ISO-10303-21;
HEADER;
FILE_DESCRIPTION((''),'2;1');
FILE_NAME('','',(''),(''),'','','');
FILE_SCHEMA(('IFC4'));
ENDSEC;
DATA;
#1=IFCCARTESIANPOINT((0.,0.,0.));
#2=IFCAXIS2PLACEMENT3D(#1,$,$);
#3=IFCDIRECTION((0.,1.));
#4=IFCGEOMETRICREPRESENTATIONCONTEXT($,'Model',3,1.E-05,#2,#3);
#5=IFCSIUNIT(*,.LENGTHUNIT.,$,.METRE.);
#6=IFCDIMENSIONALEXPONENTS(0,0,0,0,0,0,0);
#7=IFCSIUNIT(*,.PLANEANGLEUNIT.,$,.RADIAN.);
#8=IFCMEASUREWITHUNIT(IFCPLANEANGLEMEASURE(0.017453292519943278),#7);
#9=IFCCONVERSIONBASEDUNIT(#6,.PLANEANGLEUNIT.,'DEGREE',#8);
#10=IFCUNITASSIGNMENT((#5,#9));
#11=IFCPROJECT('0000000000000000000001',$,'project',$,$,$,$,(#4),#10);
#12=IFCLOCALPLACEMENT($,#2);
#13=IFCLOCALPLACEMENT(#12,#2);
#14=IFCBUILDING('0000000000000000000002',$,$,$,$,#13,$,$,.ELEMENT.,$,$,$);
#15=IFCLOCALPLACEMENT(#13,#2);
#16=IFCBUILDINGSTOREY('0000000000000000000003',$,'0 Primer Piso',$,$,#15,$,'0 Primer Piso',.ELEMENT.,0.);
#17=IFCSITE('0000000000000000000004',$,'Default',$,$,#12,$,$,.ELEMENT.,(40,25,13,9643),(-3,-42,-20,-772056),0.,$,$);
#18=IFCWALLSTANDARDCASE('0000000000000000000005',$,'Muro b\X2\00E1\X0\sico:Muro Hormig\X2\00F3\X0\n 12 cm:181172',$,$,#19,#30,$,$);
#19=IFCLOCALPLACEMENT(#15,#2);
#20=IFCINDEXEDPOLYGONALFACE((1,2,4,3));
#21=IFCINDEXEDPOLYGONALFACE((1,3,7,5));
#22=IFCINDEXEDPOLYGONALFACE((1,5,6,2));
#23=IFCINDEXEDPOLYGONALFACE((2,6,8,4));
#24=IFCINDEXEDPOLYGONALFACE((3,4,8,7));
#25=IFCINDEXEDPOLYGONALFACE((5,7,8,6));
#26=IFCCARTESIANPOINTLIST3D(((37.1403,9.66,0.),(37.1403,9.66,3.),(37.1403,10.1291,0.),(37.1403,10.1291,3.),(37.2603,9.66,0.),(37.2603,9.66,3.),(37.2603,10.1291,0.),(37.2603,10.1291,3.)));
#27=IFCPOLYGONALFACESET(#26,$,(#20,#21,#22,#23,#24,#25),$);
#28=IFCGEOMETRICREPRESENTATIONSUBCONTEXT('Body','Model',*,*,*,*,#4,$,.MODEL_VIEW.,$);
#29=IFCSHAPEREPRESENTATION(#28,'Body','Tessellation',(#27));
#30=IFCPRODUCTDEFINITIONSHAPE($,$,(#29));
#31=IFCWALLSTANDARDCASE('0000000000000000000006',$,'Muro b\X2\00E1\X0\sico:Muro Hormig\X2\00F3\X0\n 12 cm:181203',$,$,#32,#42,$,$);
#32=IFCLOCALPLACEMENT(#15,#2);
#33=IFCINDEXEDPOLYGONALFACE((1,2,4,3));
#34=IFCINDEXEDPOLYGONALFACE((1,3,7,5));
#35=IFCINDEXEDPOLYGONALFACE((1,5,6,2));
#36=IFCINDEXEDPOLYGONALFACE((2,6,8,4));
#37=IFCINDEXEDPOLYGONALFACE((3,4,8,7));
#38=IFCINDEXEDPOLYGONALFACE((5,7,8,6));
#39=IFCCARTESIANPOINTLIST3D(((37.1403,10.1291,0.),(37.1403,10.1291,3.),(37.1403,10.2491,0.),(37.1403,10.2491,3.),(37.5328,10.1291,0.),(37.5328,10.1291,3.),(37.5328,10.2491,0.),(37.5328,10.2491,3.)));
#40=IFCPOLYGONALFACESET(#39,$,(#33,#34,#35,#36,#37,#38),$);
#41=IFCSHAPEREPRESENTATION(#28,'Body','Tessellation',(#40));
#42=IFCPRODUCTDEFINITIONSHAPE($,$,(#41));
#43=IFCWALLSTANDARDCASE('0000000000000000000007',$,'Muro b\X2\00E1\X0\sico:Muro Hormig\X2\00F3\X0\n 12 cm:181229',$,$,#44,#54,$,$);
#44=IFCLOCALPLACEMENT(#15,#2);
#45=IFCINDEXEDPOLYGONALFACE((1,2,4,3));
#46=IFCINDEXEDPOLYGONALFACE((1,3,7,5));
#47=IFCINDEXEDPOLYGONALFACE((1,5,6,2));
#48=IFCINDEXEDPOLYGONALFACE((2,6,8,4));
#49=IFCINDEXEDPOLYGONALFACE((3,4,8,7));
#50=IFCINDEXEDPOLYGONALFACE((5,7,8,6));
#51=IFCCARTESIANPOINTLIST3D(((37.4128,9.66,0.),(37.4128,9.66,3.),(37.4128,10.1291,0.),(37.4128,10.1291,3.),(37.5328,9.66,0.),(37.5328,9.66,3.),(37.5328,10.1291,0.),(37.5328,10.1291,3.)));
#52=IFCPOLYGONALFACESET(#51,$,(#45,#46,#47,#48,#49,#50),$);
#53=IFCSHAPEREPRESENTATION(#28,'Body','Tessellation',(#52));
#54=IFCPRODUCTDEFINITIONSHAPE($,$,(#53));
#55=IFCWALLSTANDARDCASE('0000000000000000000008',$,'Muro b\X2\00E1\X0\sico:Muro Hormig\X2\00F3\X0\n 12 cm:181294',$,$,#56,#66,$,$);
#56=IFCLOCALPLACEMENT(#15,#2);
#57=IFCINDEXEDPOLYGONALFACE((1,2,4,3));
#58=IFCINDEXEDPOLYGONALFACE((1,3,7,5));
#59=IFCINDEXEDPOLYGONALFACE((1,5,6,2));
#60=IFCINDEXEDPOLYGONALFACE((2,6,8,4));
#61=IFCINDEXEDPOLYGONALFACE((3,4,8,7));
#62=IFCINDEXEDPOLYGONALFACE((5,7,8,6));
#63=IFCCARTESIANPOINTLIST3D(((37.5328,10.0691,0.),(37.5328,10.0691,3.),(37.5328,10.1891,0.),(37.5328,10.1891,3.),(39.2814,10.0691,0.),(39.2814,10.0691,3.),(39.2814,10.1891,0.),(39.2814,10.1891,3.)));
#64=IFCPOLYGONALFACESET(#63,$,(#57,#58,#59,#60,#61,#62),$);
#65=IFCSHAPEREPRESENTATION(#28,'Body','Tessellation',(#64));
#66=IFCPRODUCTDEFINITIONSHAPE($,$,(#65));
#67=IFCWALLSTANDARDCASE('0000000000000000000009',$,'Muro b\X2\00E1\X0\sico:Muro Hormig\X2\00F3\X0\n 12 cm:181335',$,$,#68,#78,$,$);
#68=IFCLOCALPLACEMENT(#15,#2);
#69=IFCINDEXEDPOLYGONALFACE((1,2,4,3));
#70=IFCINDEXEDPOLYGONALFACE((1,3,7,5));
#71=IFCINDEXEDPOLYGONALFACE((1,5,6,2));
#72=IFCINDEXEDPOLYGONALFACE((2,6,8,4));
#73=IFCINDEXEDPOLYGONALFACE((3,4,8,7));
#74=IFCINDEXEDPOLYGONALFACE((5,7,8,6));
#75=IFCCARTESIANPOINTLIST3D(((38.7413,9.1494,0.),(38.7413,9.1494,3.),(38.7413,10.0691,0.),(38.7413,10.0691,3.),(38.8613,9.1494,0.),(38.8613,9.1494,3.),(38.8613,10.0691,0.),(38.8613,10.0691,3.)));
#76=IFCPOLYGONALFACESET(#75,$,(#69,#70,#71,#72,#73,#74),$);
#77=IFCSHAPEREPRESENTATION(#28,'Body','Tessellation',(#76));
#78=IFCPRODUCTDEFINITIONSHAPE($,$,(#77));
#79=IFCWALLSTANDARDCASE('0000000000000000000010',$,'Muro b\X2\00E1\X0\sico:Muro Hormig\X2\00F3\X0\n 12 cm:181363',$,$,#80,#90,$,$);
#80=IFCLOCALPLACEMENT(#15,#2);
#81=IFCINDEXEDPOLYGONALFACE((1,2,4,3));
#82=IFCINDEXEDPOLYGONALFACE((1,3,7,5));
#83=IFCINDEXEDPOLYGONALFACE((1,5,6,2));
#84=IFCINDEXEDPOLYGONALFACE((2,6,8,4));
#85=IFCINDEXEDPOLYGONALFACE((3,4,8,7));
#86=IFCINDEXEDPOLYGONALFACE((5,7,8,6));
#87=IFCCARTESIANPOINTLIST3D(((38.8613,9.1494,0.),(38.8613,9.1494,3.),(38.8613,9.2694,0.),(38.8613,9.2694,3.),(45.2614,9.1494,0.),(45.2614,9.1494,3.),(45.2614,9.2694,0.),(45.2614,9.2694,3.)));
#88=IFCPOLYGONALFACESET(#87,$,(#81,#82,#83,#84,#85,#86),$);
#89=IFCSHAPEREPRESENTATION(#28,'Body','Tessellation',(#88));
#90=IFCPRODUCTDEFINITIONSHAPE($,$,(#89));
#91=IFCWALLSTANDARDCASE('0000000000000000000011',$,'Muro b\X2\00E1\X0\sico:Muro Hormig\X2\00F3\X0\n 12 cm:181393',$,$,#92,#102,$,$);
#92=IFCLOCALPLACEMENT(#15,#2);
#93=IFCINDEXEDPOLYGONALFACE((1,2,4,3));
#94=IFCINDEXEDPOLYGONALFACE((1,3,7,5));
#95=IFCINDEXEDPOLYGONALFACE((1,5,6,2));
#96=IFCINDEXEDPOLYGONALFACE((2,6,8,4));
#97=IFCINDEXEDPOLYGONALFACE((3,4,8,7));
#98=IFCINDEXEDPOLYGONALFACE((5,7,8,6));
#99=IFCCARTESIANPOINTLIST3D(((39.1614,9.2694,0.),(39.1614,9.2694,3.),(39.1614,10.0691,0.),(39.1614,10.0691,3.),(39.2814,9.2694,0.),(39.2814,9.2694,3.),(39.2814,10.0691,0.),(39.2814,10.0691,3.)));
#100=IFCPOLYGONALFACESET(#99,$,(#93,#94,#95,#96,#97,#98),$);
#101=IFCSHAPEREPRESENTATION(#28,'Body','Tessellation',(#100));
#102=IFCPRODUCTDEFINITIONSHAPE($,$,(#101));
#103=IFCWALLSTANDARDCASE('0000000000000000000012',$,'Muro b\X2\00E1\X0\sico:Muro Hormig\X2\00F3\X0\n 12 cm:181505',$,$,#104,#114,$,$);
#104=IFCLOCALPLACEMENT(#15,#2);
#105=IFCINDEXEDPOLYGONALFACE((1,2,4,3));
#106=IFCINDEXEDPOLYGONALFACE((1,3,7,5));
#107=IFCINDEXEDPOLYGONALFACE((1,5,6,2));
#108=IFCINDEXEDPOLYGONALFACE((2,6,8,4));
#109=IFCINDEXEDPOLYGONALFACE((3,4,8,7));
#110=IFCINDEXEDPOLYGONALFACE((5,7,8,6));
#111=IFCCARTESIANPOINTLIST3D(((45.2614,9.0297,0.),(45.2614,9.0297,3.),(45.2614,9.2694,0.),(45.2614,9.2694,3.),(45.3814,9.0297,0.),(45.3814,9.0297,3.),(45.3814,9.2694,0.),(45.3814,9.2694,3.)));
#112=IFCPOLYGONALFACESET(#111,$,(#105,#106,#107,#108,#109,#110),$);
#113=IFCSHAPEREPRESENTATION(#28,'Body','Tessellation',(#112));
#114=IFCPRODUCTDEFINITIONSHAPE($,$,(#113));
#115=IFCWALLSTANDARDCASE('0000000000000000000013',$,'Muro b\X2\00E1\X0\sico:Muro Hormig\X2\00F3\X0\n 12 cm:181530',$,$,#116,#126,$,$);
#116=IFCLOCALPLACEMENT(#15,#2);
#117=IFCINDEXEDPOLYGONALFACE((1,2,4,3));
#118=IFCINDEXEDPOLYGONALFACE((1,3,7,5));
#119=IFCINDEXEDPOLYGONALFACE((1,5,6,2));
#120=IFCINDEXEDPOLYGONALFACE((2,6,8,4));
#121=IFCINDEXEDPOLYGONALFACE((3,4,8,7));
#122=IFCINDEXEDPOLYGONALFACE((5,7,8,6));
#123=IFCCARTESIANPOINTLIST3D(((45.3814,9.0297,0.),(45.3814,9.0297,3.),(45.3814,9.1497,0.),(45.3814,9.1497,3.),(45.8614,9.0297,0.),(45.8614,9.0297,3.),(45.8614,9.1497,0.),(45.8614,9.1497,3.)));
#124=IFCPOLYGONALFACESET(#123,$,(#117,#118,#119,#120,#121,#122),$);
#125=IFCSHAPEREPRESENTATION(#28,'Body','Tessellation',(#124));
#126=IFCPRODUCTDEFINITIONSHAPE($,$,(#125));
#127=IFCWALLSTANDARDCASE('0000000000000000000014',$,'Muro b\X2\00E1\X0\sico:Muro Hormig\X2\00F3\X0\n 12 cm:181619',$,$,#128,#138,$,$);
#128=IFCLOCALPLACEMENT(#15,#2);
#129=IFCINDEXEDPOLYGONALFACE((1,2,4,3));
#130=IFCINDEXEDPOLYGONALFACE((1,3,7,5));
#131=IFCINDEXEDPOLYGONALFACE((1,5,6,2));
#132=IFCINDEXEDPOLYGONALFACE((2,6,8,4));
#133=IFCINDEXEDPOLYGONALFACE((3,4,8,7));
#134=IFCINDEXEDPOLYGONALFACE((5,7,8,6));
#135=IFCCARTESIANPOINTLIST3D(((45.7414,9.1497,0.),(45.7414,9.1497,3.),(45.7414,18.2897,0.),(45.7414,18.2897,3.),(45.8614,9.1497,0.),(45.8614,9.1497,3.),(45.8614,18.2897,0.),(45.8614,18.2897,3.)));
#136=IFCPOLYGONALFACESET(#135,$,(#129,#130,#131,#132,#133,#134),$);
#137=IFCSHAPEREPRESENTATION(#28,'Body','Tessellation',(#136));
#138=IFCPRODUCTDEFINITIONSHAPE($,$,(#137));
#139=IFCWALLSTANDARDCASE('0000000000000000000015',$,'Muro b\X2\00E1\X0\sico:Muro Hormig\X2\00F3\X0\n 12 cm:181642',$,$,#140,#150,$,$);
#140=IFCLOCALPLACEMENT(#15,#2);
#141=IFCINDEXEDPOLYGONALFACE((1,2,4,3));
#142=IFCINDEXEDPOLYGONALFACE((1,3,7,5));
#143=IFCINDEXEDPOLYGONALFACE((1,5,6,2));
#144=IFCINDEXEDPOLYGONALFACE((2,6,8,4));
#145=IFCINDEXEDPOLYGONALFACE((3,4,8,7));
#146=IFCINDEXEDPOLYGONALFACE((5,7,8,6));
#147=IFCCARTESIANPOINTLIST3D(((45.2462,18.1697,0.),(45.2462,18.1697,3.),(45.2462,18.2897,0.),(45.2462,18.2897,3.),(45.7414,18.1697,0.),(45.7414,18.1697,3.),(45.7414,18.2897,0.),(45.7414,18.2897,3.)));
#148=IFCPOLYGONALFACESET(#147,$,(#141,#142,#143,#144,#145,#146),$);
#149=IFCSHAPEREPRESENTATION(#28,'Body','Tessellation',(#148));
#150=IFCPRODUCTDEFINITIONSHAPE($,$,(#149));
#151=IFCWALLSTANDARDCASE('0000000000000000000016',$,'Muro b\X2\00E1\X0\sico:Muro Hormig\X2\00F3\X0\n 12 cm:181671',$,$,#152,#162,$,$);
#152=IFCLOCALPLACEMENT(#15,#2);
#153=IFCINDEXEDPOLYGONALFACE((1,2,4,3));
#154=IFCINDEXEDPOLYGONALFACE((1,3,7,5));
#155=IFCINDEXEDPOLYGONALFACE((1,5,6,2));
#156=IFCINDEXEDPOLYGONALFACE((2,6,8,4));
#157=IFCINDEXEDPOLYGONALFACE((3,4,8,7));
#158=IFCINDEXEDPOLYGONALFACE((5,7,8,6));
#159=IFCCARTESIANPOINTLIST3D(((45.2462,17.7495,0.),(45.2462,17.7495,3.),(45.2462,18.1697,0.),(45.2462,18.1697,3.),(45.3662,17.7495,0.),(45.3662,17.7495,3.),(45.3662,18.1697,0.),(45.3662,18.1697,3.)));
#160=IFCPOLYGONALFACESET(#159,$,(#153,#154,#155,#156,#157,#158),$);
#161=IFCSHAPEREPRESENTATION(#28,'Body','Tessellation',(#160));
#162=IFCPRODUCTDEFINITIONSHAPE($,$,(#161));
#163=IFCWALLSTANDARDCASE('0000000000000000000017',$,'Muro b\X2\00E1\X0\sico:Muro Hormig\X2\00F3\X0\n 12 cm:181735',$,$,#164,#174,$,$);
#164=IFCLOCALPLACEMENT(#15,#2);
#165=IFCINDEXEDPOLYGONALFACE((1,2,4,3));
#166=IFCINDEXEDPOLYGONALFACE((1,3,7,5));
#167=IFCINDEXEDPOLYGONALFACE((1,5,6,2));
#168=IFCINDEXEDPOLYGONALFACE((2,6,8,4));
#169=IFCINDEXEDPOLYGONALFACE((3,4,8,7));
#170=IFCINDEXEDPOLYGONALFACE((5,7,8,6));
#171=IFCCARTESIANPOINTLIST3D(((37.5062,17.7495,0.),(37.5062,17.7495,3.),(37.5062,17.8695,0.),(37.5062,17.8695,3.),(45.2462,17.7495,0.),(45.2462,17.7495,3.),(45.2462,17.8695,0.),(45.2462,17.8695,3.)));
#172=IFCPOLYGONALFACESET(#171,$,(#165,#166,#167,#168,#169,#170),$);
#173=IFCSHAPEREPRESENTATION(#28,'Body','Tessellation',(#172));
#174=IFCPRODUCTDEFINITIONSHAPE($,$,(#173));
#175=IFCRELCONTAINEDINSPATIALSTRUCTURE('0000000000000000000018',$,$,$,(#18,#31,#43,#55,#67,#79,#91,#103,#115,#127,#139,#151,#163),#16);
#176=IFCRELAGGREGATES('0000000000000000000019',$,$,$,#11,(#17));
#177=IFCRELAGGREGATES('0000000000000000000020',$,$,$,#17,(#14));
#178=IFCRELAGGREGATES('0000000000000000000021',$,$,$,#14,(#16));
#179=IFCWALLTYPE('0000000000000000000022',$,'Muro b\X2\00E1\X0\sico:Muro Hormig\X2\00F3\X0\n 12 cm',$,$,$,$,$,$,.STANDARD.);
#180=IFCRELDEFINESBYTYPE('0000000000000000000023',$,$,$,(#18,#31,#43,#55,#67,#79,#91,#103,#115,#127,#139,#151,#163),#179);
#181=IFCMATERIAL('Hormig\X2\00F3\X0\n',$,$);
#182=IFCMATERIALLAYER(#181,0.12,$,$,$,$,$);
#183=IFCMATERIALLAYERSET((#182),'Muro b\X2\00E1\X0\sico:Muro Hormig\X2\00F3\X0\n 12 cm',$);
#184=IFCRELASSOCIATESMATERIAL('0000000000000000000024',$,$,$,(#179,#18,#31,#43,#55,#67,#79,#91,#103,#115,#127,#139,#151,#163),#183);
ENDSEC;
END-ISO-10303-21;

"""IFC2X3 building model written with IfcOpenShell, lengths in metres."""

from ifc_helpers import new_model, entity, si_unit, converted_unit, direction, frame, frame_2d, origin, place, context, subcontext, project, spatial, rectangle, extrude, material, layer, layer_set, layer_usage, type_object, element, save


model = new_model("IFC2X3")

# Units and contexts
model_context = context("Model", 3, precision=1e-05, world=origin(), true_north=direction((0.0, 1.0)))
body_context = subcontext(model_context, "Body", "Model", "MODEL_VIEW")
ifc_project = project(units=[si_unit("LENGTHUNIT", "METRE"), converted_unit("PLANEANGLEUNIT", "DEGREE", entity("IfcPlaneAngleMeasure", 0.017453292519943278), si_unit("PLANEANGLEUNIT", "RADIAN"), dimensions=[0, 0, 0, 0, 0, 0, 0])], contexts=[model_context])

# Site, building, storey
site_placement = place(None, origin())
site = spatial("IfcSite", under=ifc_project, at=site_placement, Name="Default", CompositionType="ELEMENT", RefLatitude=(40, 25, 13, 9643), RefLongitude=(-3, -42, -20, -772056), RefElevation=0.0)
building_placement = place(site_placement, origin())
building = spatial("IfcBuilding", under=site, at=building_placement, CompositionType="ELEMENT")
storey_placement = place(building_placement, origin())
storey = spatial("IfcBuildingStorey", under=building, at=storey_placement, Name="0 Primer Piso", LongName="0 Primer Piso", CompositionType="ELEMENT", Elevation=0.0)

# Walls
ifc_material = material(Name="Hormigón")
ifc_layer = layer(ifc_material, 0.12)
ifc_layer_set = layer_set([ifc_layer], Name="Muro básico:Muro Hormigón 12 cm")
wall_type = type_object("IfcWallType", Name="Muro básico:Muro Hormigón 12 cm", PredefinedType="STANDARD", material=ifc_layer_set)
ifc_layer_usage_1 = layer_usage(ifc_layer_set, "AXIS2", "NEGATIVE", 0.06)
wall_1_placement = place(storey_placement, frame((37.2003, 9.66, 0.0), z_axis=(0.0, 0.0, 1.0), x_axis=(0.0, 1.0, 0.0)))
element("IfcWallStandardCase", 1, at=wall_1_placement, inside=storey, type_object=wall_type, material=ifc_layer_usage_1, Name="Muro básico:Muro Hormigón 12 cm:181172", context=body_context, shape_type="SweptSolid", body=[
    extrude(rectangle(XDim=0.4691, YDim=0.12, at=frame_2d((0.2346, 0.0), x_axis=(-1.0, 0.0))), origin(), (0.0, 0.0, 1.0), 3.0),
])
ifc_layer_usage_2 = layer_usage(ifc_layer_set, "AXIS2", "NEGATIVE", 0.06)
wall_2_placement = place(storey_placement, frame((37.1403, 10.1891, 0.0)))
element("IfcWallStandardCase", 2, at=wall_2_placement, inside=storey, type_object=wall_type, material=ifc_layer_usage_2, Name="Muro básico:Muro Hormigón 12 cm:181203", context=body_context, shape_type="SweptSolid", body=[
    extrude(rectangle(XDim=0.3925, YDim=0.12, at=frame_2d((0.1963, 0.0), x_axis=(-1.0, 0.0))), origin(), (0.0, 0.0, 1.0), 3.0),
])
ifc_layer_usage_3 = layer_usage(ifc_layer_set, "AXIS2", "NEGATIVE", 0.06)
wall_3_placement = place(storey_placement, frame((37.4728, 10.1291, 0.0), z_axis=(0.0, 0.0, 1.0), x_axis=(0.0, -1.0, 0.0)))
element("IfcWallStandardCase", 3, at=wall_3_placement, inside=storey, type_object=wall_type, material=ifc_layer_usage_3, Name="Muro básico:Muro Hormigón 12 cm:181229", context=body_context, shape_type="SweptSolid", body=[
    extrude(rectangle(XDim=0.4691, YDim=0.12, at=frame_2d((0.2346, 0.0), x_axis=(-1.0, 0.0))), origin(), (0.0, 0.0, 1.0), 3.0),
])
ifc_layer_usage_4 = layer_usage(ifc_layer_set, "AXIS2", "NEGATIVE", 0.06)
wall_4_placement = place(storey_placement, frame((37.5328, 10.1291, 0.0)))
element("IfcWallStandardCase", 4, at=wall_4_placement, inside=storey, type_object=wall_type, material=ifc_layer_usage_4, Name="Muro básico:Muro Hormigón 12 cm:181294", context=body_context, shape_type="SweptSolid", body=[
    extrude(rectangle(XDim=1.7486, YDim=0.12, at=frame_2d((0.8743, 0.0), x_axis=(-1.0, 0.0))), origin(), (0.0, 0.0, 1.0), 3.0),
])
ifc_layer_usage_5 = layer_usage(ifc_layer_set, "AXIS2", "NEGATIVE", 0.06)
wall_5_placement = place(storey_placement, frame((38.8013, 10.0691, 0.0), z_axis=(0.0, 0.0, 1.0), x_axis=(0.0, -1.0, 0.0)))
element("IfcWallStandardCase", 5, at=wall_5_placement, inside=storey, type_object=wall_type, material=ifc_layer_usage_5, Name="Muro básico:Muro Hormigón 12 cm:181335", context=body_context, shape_type="SweptSolid", body=[
    extrude(rectangle(XDim=0.9197, YDim=0.12, at=frame_2d((0.4599, 0.0), x_axis=(-1.0, 0.0))), origin(), (0.0, 0.0, 1.0), 3.0),
])
ifc_layer_usage_6 = layer_usage(ifc_layer_set, "AXIS2", "NEGATIVE", 0.06)
wall_6_placement = place(storey_placement, frame((38.8613, 9.2094, 0.0)))
element("IfcWallStandardCase", 6, at=wall_6_placement, inside=storey, type_object=wall_type, material=ifc_layer_usage_6, Name="Muro básico:Muro Hormigón 12 cm:181363", context=body_context, shape_type="SweptSolid", body=[
    extrude(rectangle(XDim=6.4001, YDim=0.12, at=frame_2d((3.2, 0.0), x_axis=(-1.0, 0.0))), origin(), (0.0, 0.0, 1.0), 3.0),
])
ifc_layer_usage_7 = layer_usage(ifc_layer_set, "AXIS2", "NEGATIVE", 0.06)
wall_7_placement = place(storey_placement, frame((39.2214, 9.2694, 0.0), z_axis=(0.0, 0.0, 1.0), x_axis=(0.0, 1.0, 0.0)))
element("IfcWallStandardCase", 7, at=wall_7_placement, inside=storey, type_object=wall_type, material=ifc_layer_usage_7, Name="Muro básico:Muro Hormigón 12 cm:181393", context=body_context, shape_type="SweptSolid", body=[
    extrude(rectangle(XDim=0.7997, YDim=0.12, at=frame_2d((0.3999, 0.0), x_axis=(-1.0, 0.0))), origin(), (0.0, 0.0, 1.0), 3.0),
])
ifc_layer_usage_8 = layer_usage(ifc_layer_set, "AXIS2", "NEGATIVE", 0.06)
wall_8_placement = place(storey_placement, frame((45.3214, 9.2694, 0.0), z_axis=(0.0, 0.0, 1.0), x_axis=(0.0, -1.0, 0.0)))
element("IfcWallStandardCase", 8, at=wall_8_placement, inside=storey, type_object=wall_type, material=ifc_layer_usage_8, Name="Muro básico:Muro Hormigón 12 cm:181505", context=body_context, shape_type="SweptSolid", body=[
    extrude(rectangle(XDim=0.2397, YDim=0.12, at=frame_2d((0.1198, 0.0), x_axis=(-1.0, 0.0))), origin(), (0.0, 0.0, 1.0), 3.0),
])
ifc_layer_usage_9 = layer_usage(ifc_layer_set, "AXIS2", "NEGATIVE", 0.06)
wall_9_placement = place(storey_placement, frame((45.3814, 9.0897, 0.0)))
element("IfcWallStandardCase", 9, at=wall_9_placement, inside=storey, type_object=wall_type, material=ifc_layer_usage_9, Name="Muro básico:Muro Hormigón 12 cm:181530", context=body_context, shape_type="SweptSolid", body=[
    extrude(rectangle(XDim=0.48, YDim=0.12, at=frame_2d((0.24, 0.0), x_axis=(-1.0, 0.0))), origin(), (0.0, 0.0, 1.0), 3.0),
])
ifc_layer_usage_10 = layer_usage(ifc_layer_set, "AXIS2", "NEGATIVE", 0.06)
wall_10_placement = place(storey_placement, frame((45.8014, 9.1497, 0.0), z_axis=(0.0, 0.0, 1.0), x_axis=(0.0, 1.0, 0.0)))
element("IfcWallStandardCase", 10, at=wall_10_placement, inside=storey, type_object=wall_type, material=ifc_layer_usage_10, Name="Muro básico:Muro Hormigón 12 cm:181619", context=body_context, shape_type="SweptSolid", body=[
    extrude(rectangle(XDim=9.14, YDim=0.12, at=frame_2d((4.57, 0.0), x_axis=(-1.0, 0.0))), origin(), (0.0, 0.0, 1.0), 3.0),
])
ifc_layer_usage_11 = layer_usage(ifc_layer_set, "AXIS2", "NEGATIVE", 0.06)
wall_11_placement = place(storey_placement, frame((45.7414, 18.2297, 0.0), z_axis=(0.0, 0.0, 1.0), x_axis=(-1.0, 0.0, 0.0)))
element("IfcWallStandardCase", 11, at=wall_11_placement, inside=storey, type_object=wall_type, material=ifc_layer_usage_11, Name="Muro básico:Muro Hormigón 12 cm:181642", context=body_context, shape_type="SweptSolid", body=[
    extrude(rectangle(XDim=0.4952, YDim=0.12, at=frame_2d((0.2476, 0.0), x_axis=(-1.0, 0.0))), origin(), (0.0, 0.0, 1.0), 3.0),
])
ifc_layer_usage_12 = layer_usage(ifc_layer_set, "AXIS2", "NEGATIVE", 0.06)
wall_12_placement = place(storey_placement, frame((45.3062, 18.1697, 0.0), z_axis=(0.0, 0.0, 1.0), x_axis=(0.0, -1.0, 0.0)))
element("IfcWallStandardCase", 12, at=wall_12_placement, inside=storey, type_object=wall_type, material=ifc_layer_usage_12, Name="Muro básico:Muro Hormigón 12 cm:181671", context=body_context, shape_type="SweptSolid", body=[
    extrude(rectangle(XDim=0.4202, YDim=0.12, at=frame_2d((0.2101, 0.0), x_axis=(-1.0, 0.0))), origin(), (0.0, 0.0, 1.0), 3.0),
])
ifc_layer_usage_13 = layer_usage(ifc_layer_set, "AXIS2", "NEGATIVE", 0.06)
wall_13_placement = place(storey_placement, frame((45.2462, 17.8095, 0.0), z_axis=(0.0, 0.0, 1.0), x_axis=(-1.0, 0.0, 0.0)))
element("IfcWallStandardCase", 13, at=wall_13_placement, inside=storey, type_object=wall_type, material=ifc_layer_usage_13, Name="Muro básico:Muro Hormigón 12 cm:181735", context=body_context, shape_type="SweptSolid", body=[
    extrude(rectangle(XDim=7.74, YDim=0.12, at=frame_2d((3.87, 0.0), x_axis=(-1.0, 0.0))), origin(), (0.0, 0.0, 1.0), 3.0),
])

save(model, "model.ifc")
